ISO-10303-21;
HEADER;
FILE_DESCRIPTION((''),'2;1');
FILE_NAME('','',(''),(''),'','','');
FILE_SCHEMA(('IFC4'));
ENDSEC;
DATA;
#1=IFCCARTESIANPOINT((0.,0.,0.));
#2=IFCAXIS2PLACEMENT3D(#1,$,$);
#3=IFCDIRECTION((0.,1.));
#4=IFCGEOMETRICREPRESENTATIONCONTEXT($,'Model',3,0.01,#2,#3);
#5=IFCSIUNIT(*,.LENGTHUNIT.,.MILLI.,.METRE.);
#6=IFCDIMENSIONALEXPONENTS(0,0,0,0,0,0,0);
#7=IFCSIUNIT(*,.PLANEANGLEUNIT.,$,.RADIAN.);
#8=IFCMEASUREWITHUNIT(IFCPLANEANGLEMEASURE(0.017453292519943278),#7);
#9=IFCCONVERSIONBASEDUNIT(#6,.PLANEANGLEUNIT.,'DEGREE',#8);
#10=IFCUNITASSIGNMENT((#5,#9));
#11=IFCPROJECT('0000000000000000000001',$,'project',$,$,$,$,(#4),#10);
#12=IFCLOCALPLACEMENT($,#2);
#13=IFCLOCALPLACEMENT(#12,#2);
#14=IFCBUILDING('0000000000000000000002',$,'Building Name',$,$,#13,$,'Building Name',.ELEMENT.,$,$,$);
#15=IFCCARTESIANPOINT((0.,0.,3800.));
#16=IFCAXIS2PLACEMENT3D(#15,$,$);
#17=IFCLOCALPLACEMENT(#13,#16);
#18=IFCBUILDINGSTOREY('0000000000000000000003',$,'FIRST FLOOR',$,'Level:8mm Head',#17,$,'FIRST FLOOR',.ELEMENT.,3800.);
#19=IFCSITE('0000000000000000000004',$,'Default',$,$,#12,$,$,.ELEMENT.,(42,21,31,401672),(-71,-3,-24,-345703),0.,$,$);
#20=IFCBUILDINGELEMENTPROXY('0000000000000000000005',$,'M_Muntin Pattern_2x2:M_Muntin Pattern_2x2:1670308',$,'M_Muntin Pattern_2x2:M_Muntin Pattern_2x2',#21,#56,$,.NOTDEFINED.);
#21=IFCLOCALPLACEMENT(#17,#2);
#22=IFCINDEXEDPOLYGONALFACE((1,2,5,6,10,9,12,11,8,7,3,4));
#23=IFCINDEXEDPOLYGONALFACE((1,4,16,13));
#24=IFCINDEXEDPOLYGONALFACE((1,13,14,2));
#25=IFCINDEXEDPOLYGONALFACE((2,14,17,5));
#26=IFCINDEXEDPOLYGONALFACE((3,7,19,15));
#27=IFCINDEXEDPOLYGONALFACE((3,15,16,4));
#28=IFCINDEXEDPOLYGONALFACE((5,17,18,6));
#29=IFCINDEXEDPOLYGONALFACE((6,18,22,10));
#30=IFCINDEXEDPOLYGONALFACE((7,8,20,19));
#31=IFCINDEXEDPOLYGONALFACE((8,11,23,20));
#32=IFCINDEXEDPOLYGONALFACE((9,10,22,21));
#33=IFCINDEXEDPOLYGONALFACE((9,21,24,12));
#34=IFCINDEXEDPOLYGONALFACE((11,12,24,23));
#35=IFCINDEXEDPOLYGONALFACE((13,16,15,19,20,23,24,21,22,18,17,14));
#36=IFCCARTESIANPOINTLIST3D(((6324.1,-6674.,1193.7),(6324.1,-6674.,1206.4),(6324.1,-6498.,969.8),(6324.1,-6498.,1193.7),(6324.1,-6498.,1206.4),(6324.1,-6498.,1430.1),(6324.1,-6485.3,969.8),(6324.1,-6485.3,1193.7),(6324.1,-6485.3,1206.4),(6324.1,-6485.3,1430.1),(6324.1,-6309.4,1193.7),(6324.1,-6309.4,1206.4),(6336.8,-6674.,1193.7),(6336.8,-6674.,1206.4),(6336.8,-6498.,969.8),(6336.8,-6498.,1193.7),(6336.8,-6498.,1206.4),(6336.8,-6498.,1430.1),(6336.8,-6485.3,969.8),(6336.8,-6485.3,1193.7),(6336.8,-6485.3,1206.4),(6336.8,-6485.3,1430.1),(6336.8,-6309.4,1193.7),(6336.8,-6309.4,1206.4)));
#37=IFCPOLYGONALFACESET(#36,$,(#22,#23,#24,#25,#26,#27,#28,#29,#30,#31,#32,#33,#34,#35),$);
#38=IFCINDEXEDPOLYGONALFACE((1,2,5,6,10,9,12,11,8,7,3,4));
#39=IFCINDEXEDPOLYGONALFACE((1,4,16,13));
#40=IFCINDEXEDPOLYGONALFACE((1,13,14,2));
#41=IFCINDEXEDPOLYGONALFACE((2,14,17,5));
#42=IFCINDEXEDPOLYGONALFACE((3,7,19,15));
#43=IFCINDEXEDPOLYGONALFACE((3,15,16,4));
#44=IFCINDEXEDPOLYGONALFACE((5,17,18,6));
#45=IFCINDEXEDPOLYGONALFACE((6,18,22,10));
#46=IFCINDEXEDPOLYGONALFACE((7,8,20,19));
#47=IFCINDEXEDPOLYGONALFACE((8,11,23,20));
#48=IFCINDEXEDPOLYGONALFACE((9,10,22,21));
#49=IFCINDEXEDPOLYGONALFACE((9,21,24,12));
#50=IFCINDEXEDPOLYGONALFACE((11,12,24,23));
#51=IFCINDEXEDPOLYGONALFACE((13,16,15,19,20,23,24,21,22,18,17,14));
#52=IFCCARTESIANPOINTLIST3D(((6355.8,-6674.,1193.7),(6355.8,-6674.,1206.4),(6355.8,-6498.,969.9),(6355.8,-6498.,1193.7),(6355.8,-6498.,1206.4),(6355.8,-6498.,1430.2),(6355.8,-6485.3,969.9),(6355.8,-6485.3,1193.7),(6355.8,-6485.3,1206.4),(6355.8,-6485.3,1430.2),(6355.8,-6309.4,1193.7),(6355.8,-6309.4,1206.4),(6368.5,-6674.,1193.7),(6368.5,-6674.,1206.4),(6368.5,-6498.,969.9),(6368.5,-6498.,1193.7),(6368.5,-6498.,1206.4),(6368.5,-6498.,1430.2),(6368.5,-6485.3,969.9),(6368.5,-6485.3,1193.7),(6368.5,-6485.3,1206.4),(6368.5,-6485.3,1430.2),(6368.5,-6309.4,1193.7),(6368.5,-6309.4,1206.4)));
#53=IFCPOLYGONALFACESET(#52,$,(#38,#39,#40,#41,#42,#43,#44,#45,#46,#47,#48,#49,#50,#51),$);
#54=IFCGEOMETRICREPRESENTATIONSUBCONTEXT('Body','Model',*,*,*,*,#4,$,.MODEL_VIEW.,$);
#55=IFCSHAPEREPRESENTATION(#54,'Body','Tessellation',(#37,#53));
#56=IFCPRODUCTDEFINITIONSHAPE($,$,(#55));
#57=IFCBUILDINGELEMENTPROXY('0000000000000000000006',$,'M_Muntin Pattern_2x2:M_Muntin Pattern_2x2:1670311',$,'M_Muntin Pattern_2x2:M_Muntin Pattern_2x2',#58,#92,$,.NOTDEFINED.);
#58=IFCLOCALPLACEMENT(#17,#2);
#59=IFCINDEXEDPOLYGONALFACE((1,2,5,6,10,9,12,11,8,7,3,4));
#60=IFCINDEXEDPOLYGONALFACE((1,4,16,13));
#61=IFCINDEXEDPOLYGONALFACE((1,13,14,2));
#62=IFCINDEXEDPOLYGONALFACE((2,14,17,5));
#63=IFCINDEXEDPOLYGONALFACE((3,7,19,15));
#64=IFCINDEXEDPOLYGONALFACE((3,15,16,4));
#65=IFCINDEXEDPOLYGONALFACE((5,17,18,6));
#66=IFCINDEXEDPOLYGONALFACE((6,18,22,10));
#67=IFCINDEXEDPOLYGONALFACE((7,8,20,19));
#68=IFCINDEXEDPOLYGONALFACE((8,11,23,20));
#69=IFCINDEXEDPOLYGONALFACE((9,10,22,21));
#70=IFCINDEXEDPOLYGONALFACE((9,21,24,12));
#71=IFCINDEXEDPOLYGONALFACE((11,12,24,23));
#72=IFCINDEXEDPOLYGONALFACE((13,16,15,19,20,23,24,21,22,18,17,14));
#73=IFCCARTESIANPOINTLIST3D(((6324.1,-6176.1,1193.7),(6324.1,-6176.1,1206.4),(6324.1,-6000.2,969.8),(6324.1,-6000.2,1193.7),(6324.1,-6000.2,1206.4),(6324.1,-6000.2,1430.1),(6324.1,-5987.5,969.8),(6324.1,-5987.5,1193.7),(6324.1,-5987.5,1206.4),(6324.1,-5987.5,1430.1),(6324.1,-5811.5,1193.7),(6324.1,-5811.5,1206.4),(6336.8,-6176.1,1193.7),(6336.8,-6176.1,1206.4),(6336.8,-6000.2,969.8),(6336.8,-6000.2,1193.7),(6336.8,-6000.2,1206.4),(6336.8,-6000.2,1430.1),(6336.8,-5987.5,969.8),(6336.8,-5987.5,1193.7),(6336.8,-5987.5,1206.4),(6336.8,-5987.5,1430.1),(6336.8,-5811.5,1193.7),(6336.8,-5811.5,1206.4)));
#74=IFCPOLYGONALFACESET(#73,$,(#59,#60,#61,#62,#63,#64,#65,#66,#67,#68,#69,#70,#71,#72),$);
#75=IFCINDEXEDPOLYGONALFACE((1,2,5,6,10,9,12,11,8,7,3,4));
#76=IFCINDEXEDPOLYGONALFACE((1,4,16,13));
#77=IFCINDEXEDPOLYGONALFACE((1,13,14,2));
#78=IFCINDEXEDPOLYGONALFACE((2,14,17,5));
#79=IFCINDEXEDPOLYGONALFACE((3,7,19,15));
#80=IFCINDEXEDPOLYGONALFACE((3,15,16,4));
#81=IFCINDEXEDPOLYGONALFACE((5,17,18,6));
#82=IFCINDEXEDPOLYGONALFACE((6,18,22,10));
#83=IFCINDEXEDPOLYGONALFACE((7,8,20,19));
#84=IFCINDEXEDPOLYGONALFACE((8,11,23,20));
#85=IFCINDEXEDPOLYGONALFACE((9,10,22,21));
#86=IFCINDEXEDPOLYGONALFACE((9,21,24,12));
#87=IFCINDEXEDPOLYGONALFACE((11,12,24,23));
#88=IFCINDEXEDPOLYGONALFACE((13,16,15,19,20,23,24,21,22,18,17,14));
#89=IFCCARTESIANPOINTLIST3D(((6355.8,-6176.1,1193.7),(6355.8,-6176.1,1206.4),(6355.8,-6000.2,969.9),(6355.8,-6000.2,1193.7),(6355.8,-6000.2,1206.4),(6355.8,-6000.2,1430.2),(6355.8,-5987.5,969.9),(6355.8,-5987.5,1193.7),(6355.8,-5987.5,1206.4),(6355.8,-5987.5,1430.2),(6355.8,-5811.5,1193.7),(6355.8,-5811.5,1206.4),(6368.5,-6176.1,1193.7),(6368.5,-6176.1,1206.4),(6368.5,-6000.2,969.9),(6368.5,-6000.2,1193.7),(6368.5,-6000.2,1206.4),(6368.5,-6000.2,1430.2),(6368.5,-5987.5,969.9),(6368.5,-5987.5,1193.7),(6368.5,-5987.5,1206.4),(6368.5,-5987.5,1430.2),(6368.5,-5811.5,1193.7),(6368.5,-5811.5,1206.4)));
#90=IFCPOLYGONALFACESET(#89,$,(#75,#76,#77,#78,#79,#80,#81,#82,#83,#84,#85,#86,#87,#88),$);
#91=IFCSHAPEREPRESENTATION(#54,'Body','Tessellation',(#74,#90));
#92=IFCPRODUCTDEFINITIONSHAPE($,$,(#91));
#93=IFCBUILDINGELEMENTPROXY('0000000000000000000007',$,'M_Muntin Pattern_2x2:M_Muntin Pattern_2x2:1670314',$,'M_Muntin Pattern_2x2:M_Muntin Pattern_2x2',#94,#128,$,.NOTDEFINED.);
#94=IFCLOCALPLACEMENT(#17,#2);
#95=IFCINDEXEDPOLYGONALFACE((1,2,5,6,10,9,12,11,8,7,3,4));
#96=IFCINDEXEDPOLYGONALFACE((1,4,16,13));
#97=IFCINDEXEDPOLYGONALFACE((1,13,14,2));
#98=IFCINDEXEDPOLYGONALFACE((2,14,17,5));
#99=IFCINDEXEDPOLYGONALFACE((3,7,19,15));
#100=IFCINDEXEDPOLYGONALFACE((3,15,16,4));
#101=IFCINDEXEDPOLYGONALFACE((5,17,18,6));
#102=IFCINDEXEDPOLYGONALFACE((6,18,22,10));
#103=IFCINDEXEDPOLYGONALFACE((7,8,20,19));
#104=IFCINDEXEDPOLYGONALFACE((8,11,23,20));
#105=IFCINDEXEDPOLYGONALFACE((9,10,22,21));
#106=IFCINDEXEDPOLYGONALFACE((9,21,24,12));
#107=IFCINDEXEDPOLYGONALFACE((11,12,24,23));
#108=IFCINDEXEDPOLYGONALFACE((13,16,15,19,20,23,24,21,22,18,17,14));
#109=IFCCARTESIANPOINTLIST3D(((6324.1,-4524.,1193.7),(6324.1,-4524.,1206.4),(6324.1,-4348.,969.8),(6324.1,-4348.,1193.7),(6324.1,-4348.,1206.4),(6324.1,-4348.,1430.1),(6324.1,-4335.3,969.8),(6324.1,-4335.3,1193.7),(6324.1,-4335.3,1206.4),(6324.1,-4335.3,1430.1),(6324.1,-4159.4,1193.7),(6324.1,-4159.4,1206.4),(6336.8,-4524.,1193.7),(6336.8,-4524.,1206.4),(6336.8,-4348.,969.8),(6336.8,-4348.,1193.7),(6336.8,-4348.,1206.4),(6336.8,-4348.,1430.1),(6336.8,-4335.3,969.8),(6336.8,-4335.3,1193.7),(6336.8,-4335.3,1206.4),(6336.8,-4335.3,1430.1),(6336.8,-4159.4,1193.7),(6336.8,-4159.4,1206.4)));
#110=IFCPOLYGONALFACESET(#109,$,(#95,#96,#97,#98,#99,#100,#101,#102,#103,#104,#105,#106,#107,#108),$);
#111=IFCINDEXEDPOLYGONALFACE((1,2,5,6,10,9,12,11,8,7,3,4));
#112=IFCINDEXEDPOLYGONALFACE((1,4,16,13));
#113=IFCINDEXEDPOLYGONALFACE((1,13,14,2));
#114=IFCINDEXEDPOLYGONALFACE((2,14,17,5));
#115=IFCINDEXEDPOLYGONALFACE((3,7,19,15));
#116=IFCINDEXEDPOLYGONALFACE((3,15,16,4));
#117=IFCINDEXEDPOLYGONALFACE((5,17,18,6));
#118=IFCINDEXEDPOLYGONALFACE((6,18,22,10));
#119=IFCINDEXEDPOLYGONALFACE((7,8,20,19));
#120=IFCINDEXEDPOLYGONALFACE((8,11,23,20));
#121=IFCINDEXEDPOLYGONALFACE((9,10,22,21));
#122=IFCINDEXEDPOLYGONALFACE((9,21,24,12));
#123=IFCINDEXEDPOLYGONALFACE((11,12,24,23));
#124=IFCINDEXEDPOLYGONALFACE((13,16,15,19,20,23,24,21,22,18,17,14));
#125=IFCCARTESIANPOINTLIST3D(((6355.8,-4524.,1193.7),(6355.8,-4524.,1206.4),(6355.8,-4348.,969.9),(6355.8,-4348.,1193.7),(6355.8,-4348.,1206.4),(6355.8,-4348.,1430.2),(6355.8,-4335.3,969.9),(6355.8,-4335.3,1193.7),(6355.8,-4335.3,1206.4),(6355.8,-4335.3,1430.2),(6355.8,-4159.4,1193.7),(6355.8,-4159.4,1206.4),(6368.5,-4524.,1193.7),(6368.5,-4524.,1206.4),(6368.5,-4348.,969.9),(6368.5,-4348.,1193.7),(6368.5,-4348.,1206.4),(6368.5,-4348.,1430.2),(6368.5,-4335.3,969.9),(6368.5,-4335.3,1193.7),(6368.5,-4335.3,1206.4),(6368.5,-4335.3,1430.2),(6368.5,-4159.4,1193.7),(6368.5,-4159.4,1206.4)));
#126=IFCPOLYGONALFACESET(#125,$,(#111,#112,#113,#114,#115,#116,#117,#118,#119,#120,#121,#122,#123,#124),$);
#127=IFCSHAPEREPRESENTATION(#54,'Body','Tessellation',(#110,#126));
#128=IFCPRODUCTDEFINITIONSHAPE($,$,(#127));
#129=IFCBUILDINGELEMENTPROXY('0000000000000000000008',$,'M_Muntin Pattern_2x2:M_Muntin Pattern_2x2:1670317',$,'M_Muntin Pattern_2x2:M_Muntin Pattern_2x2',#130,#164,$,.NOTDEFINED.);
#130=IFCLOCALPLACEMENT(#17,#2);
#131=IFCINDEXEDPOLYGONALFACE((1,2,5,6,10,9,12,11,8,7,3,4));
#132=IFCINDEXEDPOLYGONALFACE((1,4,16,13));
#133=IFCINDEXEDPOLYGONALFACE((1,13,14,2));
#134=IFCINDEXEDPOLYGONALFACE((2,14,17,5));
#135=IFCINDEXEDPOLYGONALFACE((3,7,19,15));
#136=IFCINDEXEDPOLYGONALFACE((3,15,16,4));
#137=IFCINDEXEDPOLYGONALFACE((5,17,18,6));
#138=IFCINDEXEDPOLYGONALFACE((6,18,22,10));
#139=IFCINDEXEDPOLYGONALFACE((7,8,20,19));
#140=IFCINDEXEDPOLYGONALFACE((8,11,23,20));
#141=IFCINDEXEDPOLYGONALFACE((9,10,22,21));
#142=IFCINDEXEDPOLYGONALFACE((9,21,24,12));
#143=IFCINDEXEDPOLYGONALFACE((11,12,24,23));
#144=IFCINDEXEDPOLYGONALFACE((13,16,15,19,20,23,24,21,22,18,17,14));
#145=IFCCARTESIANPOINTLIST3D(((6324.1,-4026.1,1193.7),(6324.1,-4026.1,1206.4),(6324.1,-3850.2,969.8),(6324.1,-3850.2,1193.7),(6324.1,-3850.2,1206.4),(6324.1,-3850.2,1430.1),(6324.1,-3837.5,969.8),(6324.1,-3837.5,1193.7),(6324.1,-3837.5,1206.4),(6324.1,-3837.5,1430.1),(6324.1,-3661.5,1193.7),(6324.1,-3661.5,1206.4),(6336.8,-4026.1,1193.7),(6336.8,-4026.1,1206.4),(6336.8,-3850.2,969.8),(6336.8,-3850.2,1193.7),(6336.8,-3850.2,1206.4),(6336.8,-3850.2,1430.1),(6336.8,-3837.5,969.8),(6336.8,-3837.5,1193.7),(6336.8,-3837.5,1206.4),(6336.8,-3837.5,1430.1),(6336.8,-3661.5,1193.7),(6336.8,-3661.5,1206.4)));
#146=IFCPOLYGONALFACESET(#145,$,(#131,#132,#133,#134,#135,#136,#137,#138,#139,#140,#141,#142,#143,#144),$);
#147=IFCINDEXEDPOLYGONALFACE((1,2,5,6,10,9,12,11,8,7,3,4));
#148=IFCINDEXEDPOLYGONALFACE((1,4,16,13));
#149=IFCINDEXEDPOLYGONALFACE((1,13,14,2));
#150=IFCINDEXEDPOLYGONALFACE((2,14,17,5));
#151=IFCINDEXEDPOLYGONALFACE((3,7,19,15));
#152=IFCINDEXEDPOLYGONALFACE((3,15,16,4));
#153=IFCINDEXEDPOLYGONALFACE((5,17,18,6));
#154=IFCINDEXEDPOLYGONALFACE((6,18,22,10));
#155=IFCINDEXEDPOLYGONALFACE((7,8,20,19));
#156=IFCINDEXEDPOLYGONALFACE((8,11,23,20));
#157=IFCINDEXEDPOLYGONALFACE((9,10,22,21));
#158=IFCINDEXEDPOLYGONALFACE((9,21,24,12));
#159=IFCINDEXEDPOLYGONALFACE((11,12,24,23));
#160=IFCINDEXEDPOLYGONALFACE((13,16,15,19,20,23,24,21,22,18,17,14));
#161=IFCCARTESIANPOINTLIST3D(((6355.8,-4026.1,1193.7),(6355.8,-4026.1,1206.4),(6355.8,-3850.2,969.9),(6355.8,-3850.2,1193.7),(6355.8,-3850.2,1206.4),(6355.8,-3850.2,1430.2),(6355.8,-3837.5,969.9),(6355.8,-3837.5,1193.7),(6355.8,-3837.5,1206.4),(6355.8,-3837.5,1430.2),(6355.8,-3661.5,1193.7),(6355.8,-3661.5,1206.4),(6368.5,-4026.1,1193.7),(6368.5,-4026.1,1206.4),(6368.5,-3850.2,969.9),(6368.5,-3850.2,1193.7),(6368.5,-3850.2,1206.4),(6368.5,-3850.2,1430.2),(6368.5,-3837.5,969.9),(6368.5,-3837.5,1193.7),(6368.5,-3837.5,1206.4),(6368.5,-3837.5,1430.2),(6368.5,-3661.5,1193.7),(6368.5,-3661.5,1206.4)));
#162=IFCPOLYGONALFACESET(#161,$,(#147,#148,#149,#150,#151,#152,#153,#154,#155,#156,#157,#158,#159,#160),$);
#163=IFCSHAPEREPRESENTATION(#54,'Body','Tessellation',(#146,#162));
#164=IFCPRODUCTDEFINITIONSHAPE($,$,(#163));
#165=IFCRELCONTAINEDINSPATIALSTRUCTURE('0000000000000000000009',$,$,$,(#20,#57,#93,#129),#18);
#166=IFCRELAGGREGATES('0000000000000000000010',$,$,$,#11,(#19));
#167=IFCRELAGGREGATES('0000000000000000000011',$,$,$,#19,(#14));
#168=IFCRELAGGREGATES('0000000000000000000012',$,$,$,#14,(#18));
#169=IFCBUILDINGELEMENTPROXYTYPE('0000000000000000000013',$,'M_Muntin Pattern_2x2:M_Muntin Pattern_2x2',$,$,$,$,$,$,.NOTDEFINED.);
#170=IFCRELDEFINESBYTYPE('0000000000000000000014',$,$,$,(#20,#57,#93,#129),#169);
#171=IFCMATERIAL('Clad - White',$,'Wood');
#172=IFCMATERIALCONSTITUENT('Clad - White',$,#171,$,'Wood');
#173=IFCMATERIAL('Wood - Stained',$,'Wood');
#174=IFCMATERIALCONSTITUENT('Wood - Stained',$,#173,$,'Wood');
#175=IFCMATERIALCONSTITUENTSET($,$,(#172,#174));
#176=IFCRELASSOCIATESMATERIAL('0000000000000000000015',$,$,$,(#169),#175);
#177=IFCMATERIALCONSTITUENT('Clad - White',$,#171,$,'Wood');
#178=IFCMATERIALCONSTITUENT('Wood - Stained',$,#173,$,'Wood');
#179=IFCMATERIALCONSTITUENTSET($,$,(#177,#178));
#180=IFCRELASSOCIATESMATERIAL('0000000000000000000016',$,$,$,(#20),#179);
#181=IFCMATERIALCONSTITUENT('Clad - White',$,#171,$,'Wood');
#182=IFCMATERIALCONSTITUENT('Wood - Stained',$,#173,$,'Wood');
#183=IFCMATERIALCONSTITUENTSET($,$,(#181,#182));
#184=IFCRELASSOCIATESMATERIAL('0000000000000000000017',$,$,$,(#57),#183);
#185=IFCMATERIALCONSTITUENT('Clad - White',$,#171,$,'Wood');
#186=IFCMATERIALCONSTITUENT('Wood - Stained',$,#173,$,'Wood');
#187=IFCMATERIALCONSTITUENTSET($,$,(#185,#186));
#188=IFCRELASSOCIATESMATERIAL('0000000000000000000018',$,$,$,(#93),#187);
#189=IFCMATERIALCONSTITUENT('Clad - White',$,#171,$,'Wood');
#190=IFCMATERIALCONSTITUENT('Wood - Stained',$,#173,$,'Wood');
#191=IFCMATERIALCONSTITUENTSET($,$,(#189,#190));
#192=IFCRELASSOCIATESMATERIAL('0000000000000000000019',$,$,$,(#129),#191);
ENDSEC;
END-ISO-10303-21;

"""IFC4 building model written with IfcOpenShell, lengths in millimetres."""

from ifc_helpers import new_model, entity, si_unit, converted_unit, direction, frame, origin, place, context, subcontext, project, spatial, indexed_curve, outline, extrude, source, transform, mapped, material, constituent, constituent_set, type_object, type_shapes, element, save


model = new_model("IFC4")

# Units and contexts
model_context = context("Model", 3, precision=0.01, world=origin(), true_north=direction((0.0, 1.0)))
body_context = subcontext(model_context, "Body", "Model", "MODEL_VIEW")
ifc_project = project(units=[si_unit("LENGTHUNIT", "METRE", prefix="MILLI"), converted_unit("PLANEANGLEUNIT", "DEGREE", entity("IfcPlaneAngleMeasure", 0.017453292519943278), si_unit("PLANEANGLEUNIT", "RADIAN"), dimensions=[0, 0, 0, 0, 0, 0, 0])], contexts=[model_context])

# Site, building, storey
site_placement = place(None, origin())
site = spatial("IfcSite", under=ifc_project, at=site_placement, Name="Default", CompositionType="ELEMENT", RefLatitude=(42, 21, 31, 401672), RefLongitude=(-71, -3, -24, -345703), RefElevation=0.0)
building_placement = place(site_placement, origin())
building = spatial("IfcBuilding", under=site, at=building_placement, Name="Building Name", LongName="Building Name", CompositionType="ELEMENT")
storey_placement = place(building_placement, frame((0.0, 0.0, 3800.0)))
storey = spatial("IfcBuildingStorey", under=building, at=storey_placement, Name="FIRST FLOOR", ObjectType="Level:8mm Head", LongName="FIRST FLOOR", CompositionType="ELEMENT", Elevation=3800.0)

# Shared definitions
ifc_material_1 = material(Name="Wood - Stained", Category="Wood")

# Building element proxies
ifc_material_2 = material(Name="Clad - White", Category="Wood")
ifc_constituent_1 = constituent(ifc_material_2, Name="Clad - White", Category="Wood")
ifc_constituent_2 = constituent(ifc_material_1, Name="Wood - Stained", Category="Wood")
ifc_constituent_set_1 = constituent_set(constituents=[ifc_constituent_1, ifc_constituent_2])
ifc_constituent_3 = constituent(ifc_material_2, Name="Clad - White", Category="Wood")
ifc_constituent_4 = constituent(ifc_material_1, Name="Wood - Stained", Category="Wood")
ifc_constituent_set_2 = constituent_set(constituents=[ifc_constituent_3, ifc_constituent_4])
building_element_proxy_type_1 = type_object("IfcBuildingElementProxyType", Name="M_Muntin Pattern_2x2:M_Muntin Pattern_2x2", PredefinedType="NOTDEFINED", material=ifc_constituent_set_2)
shared_shape_1 = source(origin(), body_context, "Body", "SweptSolid", [
    extrude(outline(indexed_curve([(6.4, -6.4), (230.1, -6.4), (230.1, 6.3), (6.4, 6.3), (6.4, 182.3), (-6.3, 182.3), (-6.3, 6.3), (-230.2, 6.3), (-230.2, -6.4), (-6.3, -6.4), (-6.3, -182.3), (6.4, -182.3), (6.4, -6.4)], self_intersect=False)), frame((0.0, 9.5, 230.1), z_axis=(0.0, 1.0, 0.0), x_axis=(0.0, 0.0, 1.0)), (0.0, 0.0, 1.0), 12.7),
    extrude(outline(indexed_curve([(6.4, -6.4), (230.2, -6.4), (230.2, 6.3), (6.4, 6.3), (6.4, 182.3), (-6.3, 182.3), (-6.3, 6.3), (-230.2, 6.3), (-230.2, -6.4), (-6.3, -6.4), (-6.3, -182.3), (6.4, -182.3), (6.4, -6.4)], self_intersect=False)), frame((0.0, -22.2, 230.2), z_axis=(0.0, 1.0, 0.0), x_axis=(0.0, 0.0, 1.0)), (0.0, 0.0, 1.0), 12.7),
])
type_shapes(building_element_proxy_type_1, [shared_shape_1])
proxy_1_placement = place(storey_placement, frame((6346.3, -6491.7, 969.9), z_axis=(0.0, 0.0, 1.0), x_axis=(0.0, 1.0, 0.0)))
element("IfcBuildingElementProxy", 1, at=proxy_1_placement, inside=storey, type_object=building_element_proxy_type_1, material=ifc_constituent_set_1, Name="M_Muntin Pattern_2x2:M_Muntin Pattern_2x2:1670308", ObjectType="M_Muntin Pattern_2x2:M_Muntin Pattern_2x2", PredefinedType="NOTDEFINED", context=body_context, shape_type="MappedRepresentation", body=[
    mapped(shared_shape_1, transform((0.0, 0.0, 0.0), scale=1.0)),
])
ifc_constituent_5 = constituent(ifc_material_2, Name="Clad - White", Category="Wood")
ifc_constituent_6 = constituent(ifc_material_1, Name="Wood - Stained", Category="Wood")
ifc_constituent_set_3 = constituent_set(constituents=[ifc_constituent_5, ifc_constituent_6])
proxy_2_placement = place(storey_placement, frame((6346.3, -5993.8, 969.9), z_axis=(0.0, 0.0, 1.0), x_axis=(0.0, 1.0, 0.0)))
element("IfcBuildingElementProxy", 2, at=proxy_2_placement, inside=storey, type_object=building_element_proxy_type_1, material=ifc_constituent_set_3, Name="M_Muntin Pattern_2x2:M_Muntin Pattern_2x2:1670311", ObjectType="M_Muntin Pattern_2x2:M_Muntin Pattern_2x2", PredefinedType="NOTDEFINED", context=body_context, shape_type="MappedRepresentation", body=[
    mapped(shared_shape_1, transform((0.0, 0.0, 0.0), scale=1.0)),
])
ifc_constituent_7 = constituent(ifc_material_2, Name="Clad - White", Category="Wood")
ifc_constituent_8 = constituent(ifc_material_1, Name="Wood - Stained", Category="Wood")
ifc_constituent_set_4 = constituent_set(constituents=[ifc_constituent_7, ifc_constituent_8])
proxy_3_placement = place(storey_placement, frame((6346.3, -4341.7, 969.9), z_axis=(0.0, 0.0, 1.0), x_axis=(0.0, 1.0, 0.0)))
element("IfcBuildingElementProxy", 3, at=proxy_3_placement, inside=storey, type_object=building_element_proxy_type_1, material=ifc_constituent_set_4, Name="M_Muntin Pattern_2x2:M_Muntin Pattern_2x2:1670314", ObjectType="M_Muntin Pattern_2x2:M_Muntin Pattern_2x2", PredefinedType="NOTDEFINED", context=body_context, shape_type="MappedRepresentation", body=[
    mapped(shared_shape_1, transform((0.0, 0.0, 0.0), scale=1.0)),
])
ifc_constituent_9 = constituent(ifc_material_2, Name="Clad - White", Category="Wood")
ifc_constituent_10 = constituent(ifc_material_1, Name="Wood - Stained", Category="Wood")
ifc_constituent_set_5 = constituent_set(constituents=[ifc_constituent_9, ifc_constituent_10])
proxy_4_placement = place(storey_placement, frame((6346.3, -3843.8, 969.9), z_axis=(0.0, 0.0, 1.0), x_axis=(0.0, 1.0, 0.0)))
element("IfcBuildingElementProxy", 4, at=proxy_4_placement, inside=storey, type_object=building_element_proxy_type_1, material=ifc_constituent_set_5, Name="M_Muntin Pattern_2x2:M_Muntin Pattern_2x2:1670317", ObjectType="M_Muntin Pattern_2x2:M_Muntin Pattern_2x2", PredefinedType="NOTDEFINED", context=body_context, shape_type="MappedRepresentation", body=[
    mapped(shared_shape_1, transform((0.0, 0.0, 0.0), scale=1.0)),
])

save(model, "model.ifc")
